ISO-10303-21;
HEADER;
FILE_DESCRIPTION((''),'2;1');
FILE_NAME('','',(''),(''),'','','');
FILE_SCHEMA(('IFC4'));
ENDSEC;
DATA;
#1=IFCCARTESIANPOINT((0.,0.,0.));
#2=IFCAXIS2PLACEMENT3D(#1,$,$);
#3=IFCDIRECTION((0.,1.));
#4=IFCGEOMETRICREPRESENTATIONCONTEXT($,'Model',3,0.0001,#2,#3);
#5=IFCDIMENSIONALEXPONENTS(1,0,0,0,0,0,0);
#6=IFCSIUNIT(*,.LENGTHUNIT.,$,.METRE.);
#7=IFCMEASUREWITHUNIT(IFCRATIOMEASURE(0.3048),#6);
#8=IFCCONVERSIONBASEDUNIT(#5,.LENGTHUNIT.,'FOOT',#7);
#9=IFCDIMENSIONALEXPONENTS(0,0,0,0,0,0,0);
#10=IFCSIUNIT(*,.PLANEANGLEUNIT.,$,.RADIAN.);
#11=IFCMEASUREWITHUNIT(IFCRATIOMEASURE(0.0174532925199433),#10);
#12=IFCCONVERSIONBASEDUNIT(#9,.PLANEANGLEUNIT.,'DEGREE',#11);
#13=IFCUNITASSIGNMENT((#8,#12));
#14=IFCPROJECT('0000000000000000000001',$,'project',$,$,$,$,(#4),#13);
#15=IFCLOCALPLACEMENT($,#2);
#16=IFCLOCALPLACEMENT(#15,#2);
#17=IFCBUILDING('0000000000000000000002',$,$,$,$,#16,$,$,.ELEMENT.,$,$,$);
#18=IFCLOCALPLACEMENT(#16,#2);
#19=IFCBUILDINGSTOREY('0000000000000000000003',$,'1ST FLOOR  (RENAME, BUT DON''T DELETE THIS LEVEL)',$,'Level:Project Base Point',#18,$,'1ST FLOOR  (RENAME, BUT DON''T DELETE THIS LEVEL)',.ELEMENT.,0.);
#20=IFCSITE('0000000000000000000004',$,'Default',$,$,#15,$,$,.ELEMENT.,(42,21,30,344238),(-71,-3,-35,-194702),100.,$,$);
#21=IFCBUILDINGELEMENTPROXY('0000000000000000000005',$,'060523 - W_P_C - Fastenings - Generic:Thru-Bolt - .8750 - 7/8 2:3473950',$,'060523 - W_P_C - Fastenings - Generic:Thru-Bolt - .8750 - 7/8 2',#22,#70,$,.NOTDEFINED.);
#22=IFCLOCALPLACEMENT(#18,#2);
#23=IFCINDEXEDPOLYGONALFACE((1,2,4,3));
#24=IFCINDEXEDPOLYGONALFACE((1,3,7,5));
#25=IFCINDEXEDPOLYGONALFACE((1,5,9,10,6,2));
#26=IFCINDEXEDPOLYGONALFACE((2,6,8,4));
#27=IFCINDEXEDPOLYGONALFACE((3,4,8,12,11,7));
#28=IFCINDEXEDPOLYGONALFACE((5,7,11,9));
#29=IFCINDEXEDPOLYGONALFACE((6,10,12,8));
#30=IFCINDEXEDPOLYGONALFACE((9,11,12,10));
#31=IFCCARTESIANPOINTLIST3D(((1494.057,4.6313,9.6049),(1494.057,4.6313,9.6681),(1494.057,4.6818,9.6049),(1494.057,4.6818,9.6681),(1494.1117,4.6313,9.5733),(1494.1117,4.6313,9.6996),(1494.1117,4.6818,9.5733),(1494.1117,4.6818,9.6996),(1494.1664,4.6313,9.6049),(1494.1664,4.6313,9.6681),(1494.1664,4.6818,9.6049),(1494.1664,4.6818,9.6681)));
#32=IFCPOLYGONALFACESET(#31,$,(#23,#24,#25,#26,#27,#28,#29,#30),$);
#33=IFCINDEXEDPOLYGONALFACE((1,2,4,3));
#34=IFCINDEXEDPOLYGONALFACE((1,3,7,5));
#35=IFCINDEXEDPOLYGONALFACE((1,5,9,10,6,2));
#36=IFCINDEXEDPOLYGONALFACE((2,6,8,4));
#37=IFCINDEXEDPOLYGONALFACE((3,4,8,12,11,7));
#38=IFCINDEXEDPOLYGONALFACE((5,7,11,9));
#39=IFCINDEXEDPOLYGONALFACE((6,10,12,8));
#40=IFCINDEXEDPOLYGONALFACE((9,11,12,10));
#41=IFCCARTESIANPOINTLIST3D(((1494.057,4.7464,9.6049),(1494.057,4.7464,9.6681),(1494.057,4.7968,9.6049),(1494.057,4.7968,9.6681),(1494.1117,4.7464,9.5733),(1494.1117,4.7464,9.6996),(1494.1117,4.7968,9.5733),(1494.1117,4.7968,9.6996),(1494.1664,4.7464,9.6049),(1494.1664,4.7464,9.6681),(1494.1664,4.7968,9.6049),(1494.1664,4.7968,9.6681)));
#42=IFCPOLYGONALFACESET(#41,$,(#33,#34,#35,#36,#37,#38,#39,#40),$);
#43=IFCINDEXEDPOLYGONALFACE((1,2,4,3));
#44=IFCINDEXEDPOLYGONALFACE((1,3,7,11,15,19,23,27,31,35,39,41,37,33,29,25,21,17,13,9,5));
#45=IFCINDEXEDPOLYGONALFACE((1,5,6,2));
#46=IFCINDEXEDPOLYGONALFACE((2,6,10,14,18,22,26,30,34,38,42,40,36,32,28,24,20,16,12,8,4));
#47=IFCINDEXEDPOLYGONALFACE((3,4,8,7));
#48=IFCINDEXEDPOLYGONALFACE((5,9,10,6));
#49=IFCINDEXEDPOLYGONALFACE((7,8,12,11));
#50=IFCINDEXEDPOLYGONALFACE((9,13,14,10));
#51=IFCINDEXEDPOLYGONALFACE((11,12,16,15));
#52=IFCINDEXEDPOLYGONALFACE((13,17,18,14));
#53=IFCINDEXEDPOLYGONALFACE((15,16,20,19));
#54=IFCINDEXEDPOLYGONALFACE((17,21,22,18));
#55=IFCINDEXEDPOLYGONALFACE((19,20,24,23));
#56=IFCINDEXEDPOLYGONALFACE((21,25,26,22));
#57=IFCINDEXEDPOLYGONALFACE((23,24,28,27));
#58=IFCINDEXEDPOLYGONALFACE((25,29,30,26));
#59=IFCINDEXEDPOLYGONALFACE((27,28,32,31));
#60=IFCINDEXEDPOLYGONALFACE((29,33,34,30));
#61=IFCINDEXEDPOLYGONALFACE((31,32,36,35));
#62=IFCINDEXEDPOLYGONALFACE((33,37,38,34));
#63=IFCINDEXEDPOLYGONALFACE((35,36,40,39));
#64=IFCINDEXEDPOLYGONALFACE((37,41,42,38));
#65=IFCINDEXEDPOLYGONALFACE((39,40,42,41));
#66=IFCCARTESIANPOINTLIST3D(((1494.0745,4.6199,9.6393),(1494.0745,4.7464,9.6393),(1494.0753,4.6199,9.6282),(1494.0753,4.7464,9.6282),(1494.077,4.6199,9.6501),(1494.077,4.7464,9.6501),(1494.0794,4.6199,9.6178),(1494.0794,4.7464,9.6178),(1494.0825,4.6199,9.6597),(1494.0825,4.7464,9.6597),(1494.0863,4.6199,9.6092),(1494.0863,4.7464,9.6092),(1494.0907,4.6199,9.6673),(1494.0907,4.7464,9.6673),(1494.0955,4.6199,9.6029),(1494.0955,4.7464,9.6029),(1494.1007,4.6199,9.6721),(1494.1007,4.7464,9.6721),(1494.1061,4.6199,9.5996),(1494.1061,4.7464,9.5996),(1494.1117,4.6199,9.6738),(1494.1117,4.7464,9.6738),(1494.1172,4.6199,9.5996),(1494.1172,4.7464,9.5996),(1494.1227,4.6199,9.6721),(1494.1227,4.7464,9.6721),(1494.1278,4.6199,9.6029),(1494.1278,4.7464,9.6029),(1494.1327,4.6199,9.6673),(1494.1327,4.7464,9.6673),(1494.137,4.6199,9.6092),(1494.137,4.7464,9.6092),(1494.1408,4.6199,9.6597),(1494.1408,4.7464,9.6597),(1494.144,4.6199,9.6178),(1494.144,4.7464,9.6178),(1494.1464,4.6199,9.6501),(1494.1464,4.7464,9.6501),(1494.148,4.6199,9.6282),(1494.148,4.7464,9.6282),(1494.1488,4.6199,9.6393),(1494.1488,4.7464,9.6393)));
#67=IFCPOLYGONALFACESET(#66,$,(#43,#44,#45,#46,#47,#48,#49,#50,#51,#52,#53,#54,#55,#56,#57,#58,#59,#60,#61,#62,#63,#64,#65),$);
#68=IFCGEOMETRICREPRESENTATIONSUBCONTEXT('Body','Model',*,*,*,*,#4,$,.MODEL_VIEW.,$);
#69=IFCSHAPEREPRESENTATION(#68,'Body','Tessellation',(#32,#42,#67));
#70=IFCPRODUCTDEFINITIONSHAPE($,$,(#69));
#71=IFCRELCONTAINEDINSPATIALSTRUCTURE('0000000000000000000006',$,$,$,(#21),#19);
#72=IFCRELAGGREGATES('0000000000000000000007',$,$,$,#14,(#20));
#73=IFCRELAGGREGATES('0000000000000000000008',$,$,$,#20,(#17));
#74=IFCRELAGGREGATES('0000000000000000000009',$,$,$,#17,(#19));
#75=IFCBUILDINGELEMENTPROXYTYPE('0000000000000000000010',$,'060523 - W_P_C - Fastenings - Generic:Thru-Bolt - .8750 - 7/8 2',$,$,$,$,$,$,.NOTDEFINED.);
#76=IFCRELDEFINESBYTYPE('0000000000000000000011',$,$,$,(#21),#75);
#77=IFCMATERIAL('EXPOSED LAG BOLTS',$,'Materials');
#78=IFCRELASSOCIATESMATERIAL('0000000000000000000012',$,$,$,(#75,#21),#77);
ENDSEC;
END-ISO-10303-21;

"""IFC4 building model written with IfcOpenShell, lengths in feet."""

from ifc_helpers import new_model, entity, si_unit, converted_unit, direction, frame, frame_2d, origin, place, context, subcontext, project, spatial, polyline, circle, outline, extrude, source, transform, mapped, material, type_object, type_shapes, element, save


model = new_model("IFC4")

# Units and contexts
model_context = context("Model", 3, precision=0.0001, world=origin(), true_north=direction((0.0, 1.0)))
body_context = subcontext(model_context, "Body", "Model", "MODEL_VIEW")
ifc_project = project(units=[converted_unit("LENGTHUNIT", "FOOT", entity("IfcRatioMeasure", 0.3048), si_unit("LENGTHUNIT", "METRE"), dimensions=[1, 0, 0, 0, 0, 0, 0]), converted_unit("PLANEANGLEUNIT", "DEGREE", entity("IfcRatioMeasure", 0.0174532925199433), si_unit("PLANEANGLEUNIT", "RADIAN"), dimensions=[0, 0, 0, 0, 0, 0, 0])], contexts=[model_context])

# Site, building, storey
site_placement = place(None, origin())
site = spatial("IfcSite", under=ifc_project, at=site_placement, Name="Default", CompositionType="ELEMENT", RefLatitude=(42, 21, 30, 344238), RefLongitude=(-71, -3, -35, -194702), RefElevation=100.0)
building_placement = place(site_placement, origin())
building = spatial("IfcBuilding", under=site, at=building_placement, CompositionType="ELEMENT")
storey_placement = place(building_placement, origin())
storey = spatial("IfcBuildingStorey", under=building, at=storey_placement, Name="1ST FLOOR  (RENAME, BUT DON'T DELETE THIS LEVEL)", ObjectType="Level:Project Base Point", LongName="1ST FLOOR  (RENAME, BUT DON'T DELETE THIS LEVEL)", CompositionType="ELEMENT", Elevation=0.0)

# Building element proxy
ifc_material_1 = material(Name="EXPOSED LAG BOLTS", Category="Materials")
building_element_proxy_type_1 = type_object("IfcBuildingElementProxyType", Name="060523 - W_P_C - Fastenings - Generic:Thru-Bolt - .8750 - 7/8 2", PredefinedType="NOTDEFINED", material=ifc_material_1)
shared_shape_1 = source(origin(), body_context, "Body", "SweptSolid", [
    extrude(outline(polyline([(-0.0316, -0.0547), (0.0316, -0.0547), (0.0631, 0.0), (0.0316, 0.0547), (-0.0316, 0.0547), (-0.0631, 0.0), (-0.0316, -0.0547)])), frame((0.0, 0.0, -0.115), z_axis=(0.0, 0.0, 1.0), x_axis=(0.866025, -0.5, 0.0)), (0.0, 0.0, 1.0), 0.0505),
    extrude(outline(polyline([(-0.0316, -0.0547), (0.0316, -0.0547), (0.0631, 0.0), (0.0316, 0.0547), (-0.0316, 0.0547), (-0.0631, 0.0), (-0.0316, -0.0547)])), frame((0.0, 0.0, 0.0), z_axis=(0.0, 0.0, 1.0), x_axis=(0.0, -1.0, 0.0)), (0.0, 0.0, 1.0), 0.0505),
    extrude(circle(Radius=0.0373, at=frame_2d((0.0, 0.0), x_axis=(1.0, 0.0))), frame((0.0, 0.0, -0.1265), z_axis=(0.0, 0.0, 1.0), x_axis=(0.0, 1.0, 0.0)), (0.0, 0.0, 1.0), 0.1265),
])
type_shapes(building_element_proxy_type_1, [shared_shape_1])
proxy_1_placement = place(storey_placement, frame((1494.1117, 4.7464, 9.6365), z_axis=(0.0, 1.0, 0.0), x_axis=(-1.0, 0.0, 0.0)))
element("IfcBuildingElementProxy", 1, at=proxy_1_placement, inside=storey, type_object=building_element_proxy_type_1, material=ifc_material_1, Name="060523 - W_P_C - Fastenings - Generic:Thru-Bolt - .8750 - 7/8 2:3473950", ObjectType="060523 - W_P_C - Fastenings - Generic:Thru-Bolt - .8750 - 7/8 2", PredefinedType="NOTDEFINED", context=body_context, shape_type="MappedRepresentation", body=[
    mapped(shared_shape_1, transform((0.0, 0.0, 0.0), scale=1.0)),
])

save(model, "model.ifc")
